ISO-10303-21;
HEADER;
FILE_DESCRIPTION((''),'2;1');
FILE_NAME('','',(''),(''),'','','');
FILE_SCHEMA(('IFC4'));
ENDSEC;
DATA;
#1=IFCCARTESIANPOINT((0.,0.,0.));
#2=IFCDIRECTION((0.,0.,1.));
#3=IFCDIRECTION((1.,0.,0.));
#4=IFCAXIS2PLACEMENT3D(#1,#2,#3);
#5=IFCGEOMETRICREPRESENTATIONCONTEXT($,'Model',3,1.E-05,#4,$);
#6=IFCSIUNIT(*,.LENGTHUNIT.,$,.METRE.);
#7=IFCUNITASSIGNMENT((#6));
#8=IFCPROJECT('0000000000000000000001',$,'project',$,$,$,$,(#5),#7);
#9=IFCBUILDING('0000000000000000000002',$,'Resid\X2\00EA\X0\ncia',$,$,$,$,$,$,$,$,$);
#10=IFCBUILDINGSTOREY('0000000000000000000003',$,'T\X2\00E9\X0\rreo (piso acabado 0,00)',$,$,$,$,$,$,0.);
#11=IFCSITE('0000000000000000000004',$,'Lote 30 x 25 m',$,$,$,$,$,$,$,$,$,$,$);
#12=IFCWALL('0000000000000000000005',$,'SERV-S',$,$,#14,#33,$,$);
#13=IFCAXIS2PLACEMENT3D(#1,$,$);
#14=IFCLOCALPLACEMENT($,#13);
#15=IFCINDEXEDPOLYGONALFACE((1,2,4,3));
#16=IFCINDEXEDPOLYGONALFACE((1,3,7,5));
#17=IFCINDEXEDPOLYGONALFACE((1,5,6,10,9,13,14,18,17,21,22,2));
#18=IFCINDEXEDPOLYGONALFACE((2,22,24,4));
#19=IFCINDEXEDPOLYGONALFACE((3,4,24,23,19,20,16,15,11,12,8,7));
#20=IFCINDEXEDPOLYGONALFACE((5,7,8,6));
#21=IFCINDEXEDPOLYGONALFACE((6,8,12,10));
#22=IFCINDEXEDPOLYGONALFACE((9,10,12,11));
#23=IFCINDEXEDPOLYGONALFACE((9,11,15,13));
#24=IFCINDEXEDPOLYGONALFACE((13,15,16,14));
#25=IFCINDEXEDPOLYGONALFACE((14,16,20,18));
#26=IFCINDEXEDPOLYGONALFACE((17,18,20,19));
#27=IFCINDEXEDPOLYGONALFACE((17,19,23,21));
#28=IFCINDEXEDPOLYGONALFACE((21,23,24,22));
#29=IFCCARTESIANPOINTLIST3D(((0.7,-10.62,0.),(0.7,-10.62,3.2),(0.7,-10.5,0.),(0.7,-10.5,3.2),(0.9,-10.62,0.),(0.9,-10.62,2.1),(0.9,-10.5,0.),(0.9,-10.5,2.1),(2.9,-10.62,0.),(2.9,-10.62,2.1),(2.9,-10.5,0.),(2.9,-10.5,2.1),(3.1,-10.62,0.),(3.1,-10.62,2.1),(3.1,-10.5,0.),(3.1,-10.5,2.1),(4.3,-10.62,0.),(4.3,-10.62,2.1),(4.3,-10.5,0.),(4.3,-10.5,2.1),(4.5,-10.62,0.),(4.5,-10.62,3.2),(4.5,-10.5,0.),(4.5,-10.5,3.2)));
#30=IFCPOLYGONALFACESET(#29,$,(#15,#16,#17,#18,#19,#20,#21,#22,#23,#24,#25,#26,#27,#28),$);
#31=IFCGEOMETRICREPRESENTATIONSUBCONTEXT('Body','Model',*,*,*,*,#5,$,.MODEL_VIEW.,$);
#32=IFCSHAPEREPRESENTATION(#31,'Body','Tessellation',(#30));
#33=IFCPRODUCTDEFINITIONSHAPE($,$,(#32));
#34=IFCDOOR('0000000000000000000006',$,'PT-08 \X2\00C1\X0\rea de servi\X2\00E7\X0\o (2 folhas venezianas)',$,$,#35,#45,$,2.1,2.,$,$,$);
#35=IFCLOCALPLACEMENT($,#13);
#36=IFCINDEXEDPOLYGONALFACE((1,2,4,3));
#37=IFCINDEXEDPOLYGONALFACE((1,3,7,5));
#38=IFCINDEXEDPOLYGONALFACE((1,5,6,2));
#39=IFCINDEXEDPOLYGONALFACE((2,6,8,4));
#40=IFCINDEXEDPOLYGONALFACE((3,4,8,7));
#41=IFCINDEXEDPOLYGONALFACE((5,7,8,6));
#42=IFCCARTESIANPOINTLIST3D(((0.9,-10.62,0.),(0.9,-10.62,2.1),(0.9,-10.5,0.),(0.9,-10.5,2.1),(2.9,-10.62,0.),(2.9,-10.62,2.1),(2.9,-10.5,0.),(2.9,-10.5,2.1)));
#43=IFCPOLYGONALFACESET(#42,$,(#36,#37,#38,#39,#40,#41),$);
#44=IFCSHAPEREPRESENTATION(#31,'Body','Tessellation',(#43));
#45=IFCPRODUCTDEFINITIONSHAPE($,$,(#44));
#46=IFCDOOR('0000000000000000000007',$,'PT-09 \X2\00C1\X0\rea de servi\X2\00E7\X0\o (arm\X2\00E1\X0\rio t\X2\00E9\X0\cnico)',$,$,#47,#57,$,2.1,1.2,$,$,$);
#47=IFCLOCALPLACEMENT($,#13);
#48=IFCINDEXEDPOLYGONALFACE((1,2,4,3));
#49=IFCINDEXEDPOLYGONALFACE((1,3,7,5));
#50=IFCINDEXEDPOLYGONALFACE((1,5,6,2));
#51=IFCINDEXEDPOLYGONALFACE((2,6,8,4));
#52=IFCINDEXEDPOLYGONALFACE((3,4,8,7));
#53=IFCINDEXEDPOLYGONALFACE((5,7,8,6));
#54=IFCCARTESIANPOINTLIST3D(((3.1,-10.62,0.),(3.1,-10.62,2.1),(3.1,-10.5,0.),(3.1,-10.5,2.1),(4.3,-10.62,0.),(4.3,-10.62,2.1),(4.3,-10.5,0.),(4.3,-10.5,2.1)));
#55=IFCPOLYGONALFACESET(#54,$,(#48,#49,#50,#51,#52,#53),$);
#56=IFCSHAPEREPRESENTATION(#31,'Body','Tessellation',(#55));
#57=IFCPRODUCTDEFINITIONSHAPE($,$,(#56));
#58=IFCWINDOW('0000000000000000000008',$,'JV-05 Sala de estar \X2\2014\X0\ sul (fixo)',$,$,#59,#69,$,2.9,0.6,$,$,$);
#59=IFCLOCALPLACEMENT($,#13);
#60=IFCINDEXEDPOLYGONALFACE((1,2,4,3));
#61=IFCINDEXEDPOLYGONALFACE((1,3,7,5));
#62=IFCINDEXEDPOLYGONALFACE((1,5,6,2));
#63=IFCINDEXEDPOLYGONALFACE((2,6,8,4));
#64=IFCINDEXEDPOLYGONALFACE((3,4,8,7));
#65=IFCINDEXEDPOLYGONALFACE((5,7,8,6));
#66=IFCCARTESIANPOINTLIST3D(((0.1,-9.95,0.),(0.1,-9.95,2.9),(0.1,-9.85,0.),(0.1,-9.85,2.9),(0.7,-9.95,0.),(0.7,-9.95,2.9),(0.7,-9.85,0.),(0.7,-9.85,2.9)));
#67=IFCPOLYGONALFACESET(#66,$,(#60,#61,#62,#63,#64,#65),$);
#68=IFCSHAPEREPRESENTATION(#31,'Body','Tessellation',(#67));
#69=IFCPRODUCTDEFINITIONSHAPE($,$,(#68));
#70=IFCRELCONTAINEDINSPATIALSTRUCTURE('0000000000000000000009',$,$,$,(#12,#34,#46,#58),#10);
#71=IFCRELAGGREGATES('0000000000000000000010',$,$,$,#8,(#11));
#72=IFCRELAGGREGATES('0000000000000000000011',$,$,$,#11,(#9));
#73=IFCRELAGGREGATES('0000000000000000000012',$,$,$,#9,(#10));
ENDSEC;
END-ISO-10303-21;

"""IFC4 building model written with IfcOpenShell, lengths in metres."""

from ifc_helpers import new_model, si_unit, frame, origin_with_axes, place, context, subcontext, project, spatial, line, indexed_curve, outline, extrude, element, fill, save


model = new_model("IFC4")

# Units and contexts
model_context = context("Model", 3, precision=1e-05, world=origin_with_axes())
body_context = subcontext(model_context, "Body", "Model", "MODEL_VIEW")
ifc_project = project(units=[si_unit("LENGTHUNIT", "METRE")], contexts=[model_context])

# Site, building, storey
site = spatial("IfcSite", under=ifc_project, Name="Lote 30 x 25 m")
building = spatial("IfcBuilding", under=site, Name="Residência")
storey = spatial("IfcBuildingStorey", under=building, Name="Térreo (piso acabado 0,00)", Elevation=0.0)

# Wall, openings, doors
wall_1_placement = place(None, frame((0.7, -10.62, 0.0), z_axis=(0.0, 0.0, 1.0), x_axis=(1.0, 0.0, 0.0)))
wall_1 = element("IfcWall", 1, at=wall_1_placement, inside=storey, Name="SERV-S", context=body_context, shape_type="SweptSolid", body=[
    extrude(outline(indexed_curve([(0.0, 0.0), (3.8, 0.0), (3.8, 0.12), (0.0, 0.12)], segments=[line(1, 2, 3, 4, 1)])), origin_with_axes(), (0.0, 0.0, 1.0), 3.2),
])
opening_1_placement = place(wall_1_placement, frame((0.2, -0.01, 0.0), z_axis=(0.0, 0.0, 1.0), x_axis=(1.0, 0.0, 0.0)))
opening_1 = element("IfcOpeningElement", 2, at=opening_1_placement, cuts=wall_1, context=body_context, shape_type="SweptSolid", body=[
    extrude(outline(indexed_curve([(0.0, 0.0), (2.0, 0.0), (2.0, 0.14), (0.0, 0.14)], segments=[line(1, 2, 3, 4, 1)])), origin_with_axes(), (0.0, 0.0, 1.0), 2.1),
])
opening_2_placement = place(wall_1_placement, frame((2.4, -0.01, 0.0), z_axis=(0.0, 0.0, 1.0), x_axis=(1.0, 0.0, 0.0)))
opening_2 = element("IfcOpeningElement", 3, at=opening_2_placement, cuts=wall_1, context=body_context, shape_type="SweptSolid", body=[
    extrude(outline(indexed_curve([(0.0, 0.0), (1.2, 0.0), (1.2, 0.14), (0.0, 0.14)], segments=[line(1, 2, 3, 4, 1)])), origin_with_axes(), (0.0, 0.0, 1.0), 2.1),
])
door_1_placement = place(None, frame((0.9, -10.62, 0.0), z_axis=(0.0, 0.0, 1.0), x_axis=(1.0, 0.0, 0.0)))
door_1 = element("IfcDoor", 4, at=door_1_placement, inside=storey, Name="PT-08 Área de serviço (2 folhas venezianas)", OverallHeight=2.1, OverallWidth=2.0, context=body_context, shape_type="SweptSolid", body=[
    extrude(outline(indexed_curve([(0.0, 0.0), (2.0, 0.0), (2.0, 0.12), (0.0, 0.12)], segments=[line(1, 2, 3, 4, 1)])), origin_with_axes(), (0.0, 0.0, 1.0), 2.1),
])
fill(opening_1, door_1)
door_2_placement = place(None, frame((3.1, -10.62, 0.0), z_axis=(0.0, 0.0, 1.0), x_axis=(1.0, 0.0, 0.0)))
door_2 = element("IfcDoor", 5, at=door_2_placement, inside=storey, Name="PT-09 Área de serviço (armário técnico)", OverallHeight=2.1, OverallWidth=1.2, context=body_context, shape_type="SweptSolid", body=[
    extrude(outline(indexed_curve([(0.0, 0.0), (1.2, 0.0), (1.2, 0.12), (0.0, 0.12)], segments=[line(1, 2, 3, 4, 1)])), origin_with_axes(), (0.0, 0.0, 1.0), 2.1),
])
fill(opening_2, door_2)

# Window
window_placement = place(None, frame((0.1, -9.95, 0.0), z_axis=(0.0, 0.0, 1.0), x_axis=(1.0, 0.0, 0.0)))
element("IfcWindow", 6, at=window_placement, inside=storey, Name="JV-05 Sala de estar — sul (fixo)", OverallHeight=2.9, OverallWidth=0.6, context=body_context, shape_type="SweptSolid", body=[
    extrude(outline(indexed_curve([(0.0, 0.0), (0.6, 0.0), (0.6, 0.1), (0.0, 0.1)], segments=[line(1, 2, 3, 4, 1)])), origin_with_axes(), (0.0, 0.0, 1.0), 2.9),
])

save(model, "model.ifc")
